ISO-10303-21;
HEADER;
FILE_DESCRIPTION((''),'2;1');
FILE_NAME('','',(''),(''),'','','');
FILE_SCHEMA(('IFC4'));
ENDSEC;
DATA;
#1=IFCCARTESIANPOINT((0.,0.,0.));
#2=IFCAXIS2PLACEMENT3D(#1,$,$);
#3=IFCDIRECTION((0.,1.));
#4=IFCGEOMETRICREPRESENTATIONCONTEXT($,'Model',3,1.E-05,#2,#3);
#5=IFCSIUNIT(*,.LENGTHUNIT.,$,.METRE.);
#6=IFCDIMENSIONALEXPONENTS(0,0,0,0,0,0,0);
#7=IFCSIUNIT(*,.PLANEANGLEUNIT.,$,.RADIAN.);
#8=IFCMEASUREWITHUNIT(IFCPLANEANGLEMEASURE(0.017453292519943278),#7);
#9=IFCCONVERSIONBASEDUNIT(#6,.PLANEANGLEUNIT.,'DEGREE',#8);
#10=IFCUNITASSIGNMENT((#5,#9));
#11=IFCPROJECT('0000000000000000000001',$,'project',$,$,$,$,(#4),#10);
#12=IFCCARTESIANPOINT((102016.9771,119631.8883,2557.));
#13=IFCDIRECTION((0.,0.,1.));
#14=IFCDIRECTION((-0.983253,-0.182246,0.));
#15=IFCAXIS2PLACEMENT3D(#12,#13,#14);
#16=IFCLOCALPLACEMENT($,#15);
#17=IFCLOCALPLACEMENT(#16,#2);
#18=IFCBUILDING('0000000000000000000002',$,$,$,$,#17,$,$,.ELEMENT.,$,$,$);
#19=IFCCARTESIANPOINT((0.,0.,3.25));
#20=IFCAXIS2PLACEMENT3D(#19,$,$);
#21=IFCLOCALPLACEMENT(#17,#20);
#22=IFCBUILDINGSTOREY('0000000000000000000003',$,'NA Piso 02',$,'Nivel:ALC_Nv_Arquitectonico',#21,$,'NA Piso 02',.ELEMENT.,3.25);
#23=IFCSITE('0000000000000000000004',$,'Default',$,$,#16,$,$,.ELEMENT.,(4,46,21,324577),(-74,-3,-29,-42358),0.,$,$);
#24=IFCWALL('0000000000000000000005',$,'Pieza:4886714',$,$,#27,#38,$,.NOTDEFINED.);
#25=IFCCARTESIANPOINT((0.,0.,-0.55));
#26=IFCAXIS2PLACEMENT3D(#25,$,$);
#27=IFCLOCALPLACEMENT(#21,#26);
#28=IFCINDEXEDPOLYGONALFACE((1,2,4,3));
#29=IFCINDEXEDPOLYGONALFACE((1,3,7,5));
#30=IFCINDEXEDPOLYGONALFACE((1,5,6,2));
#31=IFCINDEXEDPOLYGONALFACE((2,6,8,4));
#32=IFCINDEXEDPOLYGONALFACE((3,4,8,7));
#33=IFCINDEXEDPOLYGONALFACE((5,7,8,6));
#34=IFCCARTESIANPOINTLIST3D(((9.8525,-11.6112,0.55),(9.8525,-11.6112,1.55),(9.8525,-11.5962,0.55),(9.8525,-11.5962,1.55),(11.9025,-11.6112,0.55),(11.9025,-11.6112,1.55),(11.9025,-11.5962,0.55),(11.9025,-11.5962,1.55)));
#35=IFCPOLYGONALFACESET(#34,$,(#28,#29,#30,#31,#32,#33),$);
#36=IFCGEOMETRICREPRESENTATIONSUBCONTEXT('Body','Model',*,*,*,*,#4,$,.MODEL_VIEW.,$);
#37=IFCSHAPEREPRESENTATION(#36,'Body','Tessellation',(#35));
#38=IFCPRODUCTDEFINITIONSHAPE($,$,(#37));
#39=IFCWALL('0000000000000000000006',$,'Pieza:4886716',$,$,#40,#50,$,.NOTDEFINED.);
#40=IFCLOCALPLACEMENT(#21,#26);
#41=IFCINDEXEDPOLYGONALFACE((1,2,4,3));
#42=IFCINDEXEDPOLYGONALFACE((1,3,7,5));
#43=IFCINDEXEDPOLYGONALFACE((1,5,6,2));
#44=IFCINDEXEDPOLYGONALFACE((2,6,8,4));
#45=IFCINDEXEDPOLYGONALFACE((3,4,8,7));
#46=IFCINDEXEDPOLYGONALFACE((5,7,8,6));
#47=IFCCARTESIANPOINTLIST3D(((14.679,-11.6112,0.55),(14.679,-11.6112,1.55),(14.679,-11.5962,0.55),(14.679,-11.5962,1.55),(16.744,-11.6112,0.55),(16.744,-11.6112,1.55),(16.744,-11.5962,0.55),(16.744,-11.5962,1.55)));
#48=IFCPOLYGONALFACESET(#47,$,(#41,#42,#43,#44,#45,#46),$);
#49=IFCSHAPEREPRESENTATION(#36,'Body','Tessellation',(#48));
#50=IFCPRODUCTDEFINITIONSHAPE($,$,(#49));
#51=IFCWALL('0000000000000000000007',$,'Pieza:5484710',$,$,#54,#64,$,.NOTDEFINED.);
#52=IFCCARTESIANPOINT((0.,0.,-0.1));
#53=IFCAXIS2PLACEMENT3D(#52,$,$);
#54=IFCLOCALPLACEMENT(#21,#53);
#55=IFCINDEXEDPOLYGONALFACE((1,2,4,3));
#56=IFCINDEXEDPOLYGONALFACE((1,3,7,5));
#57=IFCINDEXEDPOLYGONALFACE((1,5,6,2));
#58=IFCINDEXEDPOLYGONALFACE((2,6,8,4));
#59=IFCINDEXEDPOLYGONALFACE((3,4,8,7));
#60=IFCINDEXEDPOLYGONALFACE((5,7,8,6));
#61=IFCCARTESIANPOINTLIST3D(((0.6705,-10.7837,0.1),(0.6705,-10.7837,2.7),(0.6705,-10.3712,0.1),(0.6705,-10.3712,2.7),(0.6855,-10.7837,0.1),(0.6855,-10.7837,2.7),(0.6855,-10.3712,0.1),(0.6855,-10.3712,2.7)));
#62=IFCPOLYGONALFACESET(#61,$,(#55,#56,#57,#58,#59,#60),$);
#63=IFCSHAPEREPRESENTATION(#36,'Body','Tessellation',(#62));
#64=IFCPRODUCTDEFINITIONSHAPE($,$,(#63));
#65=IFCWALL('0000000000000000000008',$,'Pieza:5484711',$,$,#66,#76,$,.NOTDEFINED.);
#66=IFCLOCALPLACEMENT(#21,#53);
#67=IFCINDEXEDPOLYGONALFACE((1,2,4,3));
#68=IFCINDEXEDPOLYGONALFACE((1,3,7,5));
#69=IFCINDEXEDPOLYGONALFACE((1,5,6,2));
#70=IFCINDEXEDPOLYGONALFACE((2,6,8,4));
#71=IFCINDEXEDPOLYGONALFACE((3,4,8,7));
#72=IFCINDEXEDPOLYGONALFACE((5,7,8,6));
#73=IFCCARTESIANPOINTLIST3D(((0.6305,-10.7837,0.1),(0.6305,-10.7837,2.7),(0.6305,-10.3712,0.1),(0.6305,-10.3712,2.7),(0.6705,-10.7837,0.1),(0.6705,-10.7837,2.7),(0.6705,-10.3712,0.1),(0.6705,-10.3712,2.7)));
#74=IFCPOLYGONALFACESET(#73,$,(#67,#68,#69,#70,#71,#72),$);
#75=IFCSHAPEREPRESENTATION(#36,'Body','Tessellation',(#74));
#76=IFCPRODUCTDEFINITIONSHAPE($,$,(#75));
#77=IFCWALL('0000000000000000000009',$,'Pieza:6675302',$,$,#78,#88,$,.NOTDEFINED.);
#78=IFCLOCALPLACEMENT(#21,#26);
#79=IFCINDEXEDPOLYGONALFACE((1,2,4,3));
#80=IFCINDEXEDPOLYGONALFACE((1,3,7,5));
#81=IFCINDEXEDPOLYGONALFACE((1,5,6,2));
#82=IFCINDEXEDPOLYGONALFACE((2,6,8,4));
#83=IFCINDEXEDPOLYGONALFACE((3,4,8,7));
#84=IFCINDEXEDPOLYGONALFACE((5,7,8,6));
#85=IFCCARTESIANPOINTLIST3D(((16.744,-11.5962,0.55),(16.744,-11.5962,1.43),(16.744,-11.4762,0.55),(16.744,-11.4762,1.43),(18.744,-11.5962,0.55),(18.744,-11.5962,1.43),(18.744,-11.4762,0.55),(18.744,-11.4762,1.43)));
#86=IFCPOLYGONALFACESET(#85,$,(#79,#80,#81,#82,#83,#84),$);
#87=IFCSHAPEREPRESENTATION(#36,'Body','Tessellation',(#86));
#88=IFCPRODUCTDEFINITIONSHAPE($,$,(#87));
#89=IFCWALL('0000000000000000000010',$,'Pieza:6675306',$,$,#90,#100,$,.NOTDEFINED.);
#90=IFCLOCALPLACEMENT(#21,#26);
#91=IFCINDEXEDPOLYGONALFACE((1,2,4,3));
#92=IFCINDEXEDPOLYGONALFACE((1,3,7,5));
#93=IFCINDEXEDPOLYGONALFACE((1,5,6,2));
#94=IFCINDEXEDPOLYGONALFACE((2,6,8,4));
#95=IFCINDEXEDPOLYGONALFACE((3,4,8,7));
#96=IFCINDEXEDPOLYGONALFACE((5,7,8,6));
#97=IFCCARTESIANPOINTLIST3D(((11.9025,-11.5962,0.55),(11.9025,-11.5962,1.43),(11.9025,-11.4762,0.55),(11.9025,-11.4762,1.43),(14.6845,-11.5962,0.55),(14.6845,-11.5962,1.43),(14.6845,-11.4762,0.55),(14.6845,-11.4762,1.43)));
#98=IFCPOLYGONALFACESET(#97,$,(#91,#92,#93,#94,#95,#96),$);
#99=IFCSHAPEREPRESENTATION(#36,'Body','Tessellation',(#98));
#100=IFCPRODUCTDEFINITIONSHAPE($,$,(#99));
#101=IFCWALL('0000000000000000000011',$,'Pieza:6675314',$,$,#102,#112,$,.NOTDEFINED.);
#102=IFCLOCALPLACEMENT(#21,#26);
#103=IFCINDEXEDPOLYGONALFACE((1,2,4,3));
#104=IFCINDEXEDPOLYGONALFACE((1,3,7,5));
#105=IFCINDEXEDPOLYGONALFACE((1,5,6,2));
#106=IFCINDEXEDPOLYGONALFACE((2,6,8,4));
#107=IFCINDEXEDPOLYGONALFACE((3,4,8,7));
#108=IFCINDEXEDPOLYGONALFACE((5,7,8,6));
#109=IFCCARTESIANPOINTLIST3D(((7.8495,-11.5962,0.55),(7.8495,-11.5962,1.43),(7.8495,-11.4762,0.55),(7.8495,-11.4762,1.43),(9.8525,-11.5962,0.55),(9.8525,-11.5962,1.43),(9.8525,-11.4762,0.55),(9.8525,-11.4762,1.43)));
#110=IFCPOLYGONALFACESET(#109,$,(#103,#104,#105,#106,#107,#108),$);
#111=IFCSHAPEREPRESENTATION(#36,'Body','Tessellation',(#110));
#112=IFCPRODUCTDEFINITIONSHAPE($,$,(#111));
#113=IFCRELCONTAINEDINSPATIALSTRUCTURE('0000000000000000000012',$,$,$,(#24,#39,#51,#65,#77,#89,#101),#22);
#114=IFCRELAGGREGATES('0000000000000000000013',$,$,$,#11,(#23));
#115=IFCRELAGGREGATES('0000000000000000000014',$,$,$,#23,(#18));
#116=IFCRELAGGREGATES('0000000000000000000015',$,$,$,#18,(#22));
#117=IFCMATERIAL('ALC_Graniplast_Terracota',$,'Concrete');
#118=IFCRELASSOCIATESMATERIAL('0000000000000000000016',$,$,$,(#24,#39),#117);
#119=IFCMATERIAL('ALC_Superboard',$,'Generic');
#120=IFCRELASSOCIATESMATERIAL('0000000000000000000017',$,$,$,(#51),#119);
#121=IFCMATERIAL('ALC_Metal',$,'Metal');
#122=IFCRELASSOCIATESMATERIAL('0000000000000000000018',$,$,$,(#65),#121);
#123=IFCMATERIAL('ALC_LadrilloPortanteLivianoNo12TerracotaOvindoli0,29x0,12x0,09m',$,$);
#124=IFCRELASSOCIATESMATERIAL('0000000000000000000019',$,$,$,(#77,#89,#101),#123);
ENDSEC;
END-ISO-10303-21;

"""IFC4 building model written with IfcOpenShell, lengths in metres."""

from ifc_helpers import new_model, entity, si_unit, converted_unit, direction, frame, frame_2d, origin, origin_2d_with_axis, place, context, subcontext, project, spatial, rectangle, extrude, material, element, save


model = new_model("IFC4")

# Units and contexts
model_context = context("Model", 3, precision=1e-05, world=origin(), true_north=direction((0.0, 1.0)))
body_context = subcontext(model_context, "Body", "Model", "MODEL_VIEW")
ifc_project = project(units=[si_unit("LENGTHUNIT", "METRE"), converted_unit("PLANEANGLEUNIT", "DEGREE", entity("IfcPlaneAngleMeasure", 0.017453292519943278), si_unit("PLANEANGLEUNIT", "RADIAN"), dimensions=[0, 0, 0, 0, 0, 0, 0])], contexts=[model_context])

# Site, building, storey
site_placement = place(None, frame((102016.9771, 119631.8883, 2557.0), z_axis=(0.0, 0.0, 1.0), x_axis=(-0.983253, -0.182246, 0.0)))
site = spatial("IfcSite", under=ifc_project, at=site_placement, Name="Default", CompositionType="ELEMENT", RefLatitude=(4, 46, 21, 324577), RefLongitude=(-74, -3, -29, -42358), RefElevation=0.0)
building_placement = place(site_placement, origin())
building = spatial("IfcBuilding", under=site, at=building_placement, CompositionType="ELEMENT")
storey_placement = place(building_placement, frame((0.0, 0.0, 3.25)))
storey = spatial("IfcBuildingStorey", under=building, at=storey_placement, Name="NA Piso 02", ObjectType="Nivel:ALC_Nv_Arquitectonico", LongName="NA Piso 02", CompositionType="ELEMENT", Elevation=3.25)

# Walls
ifc_material_1 = material(Name="ALC_Graniplast_Terracota", Category="Concrete")
wall_1_placement = place(storey_placement, frame((0.0, 0.0, -0.55)))
element("IfcWall", 1, at=wall_1_placement, inside=storey, material=ifc_material_1, Name="Pieza:4886714", PredefinedType="NOTDEFINED", context=body_context, shape_type="SweptSolid", body=[
    extrude(rectangle(XDim=0.015, YDim=2.05, at=frame_2d((0.0, 0.0), x_axis=(1.0, 0.0))), frame((10.8775, -11.6037, 0.55), z_axis=(0.0, 0.0, 1.0), x_axis=(0.0, -1.0, 0.0)), (0.0, 0.0, 1.0), 1.0),
])
wall_2_placement = place(storey_placement, frame((0.0, 0.0, -0.55)))
element("IfcWall", 2, at=wall_2_placement, inside=storey, material=ifc_material_1, Name="Pieza:4886716", PredefinedType="NOTDEFINED", context=body_context, shape_type="SweptSolid", body=[
    extrude(rectangle(XDim=0.015, YDim=2.065, at=frame_2d((0.0, 0.0), x_axis=(1.0, 0.0))), frame((15.7115, -11.6037, 0.55), z_axis=(0.0, 0.0, 1.0), x_axis=(0.0, -1.0, 0.0)), (0.0, 0.0, 1.0), 1.0),
])
ifc_material_2 = material(Name="ALC_Superboard", Category="Generic")
wall_3_placement = place(storey_placement, frame((0.0, 0.0, -0.1)))
element("IfcWall", 3, at=wall_3_placement, inside=storey, material=ifc_material_2, Name="Pieza:5484710", PredefinedType="NOTDEFINED", context=body_context, shape_type="SweptSolid", body=[
    extrude(rectangle(XDim=0.4125, YDim=0.015, at=frame_2d((0.0, 0.0), x_axis=(1.0, 0.0))), frame((0.678, -10.5774, 0.1), z_axis=(0.0, 0.0, 1.0), x_axis=(0.0, -1.0, 0.0)), (0.0, 0.0, 1.0), 2.6),
])
ifc_material_3 = material(Name="ALC_Metal", Category="Metal")
wall_4_placement = place(storey_placement, frame((0.0, 0.0, -0.1)))
element("IfcWall", 4, at=wall_4_placement, inside=storey, material=ifc_material_3, Name="Pieza:5484711", PredefinedType="NOTDEFINED", context=body_context, shape_type="SweptSolid", body=[
    extrude(rectangle(XDim=0.4125, YDim=0.04, at=frame_2d((0.0, 0.0), x_axis=(1.0, 0.0))), frame((0.6505, -10.5774, 0.1), z_axis=(0.0, 0.0, 1.0), x_axis=(0.0, -1.0, 0.0)), (0.0, 0.0, 1.0), 2.6),
])
ifc_material_4 = material(Name="ALC_LadrilloPortanteLivianoNo12TerracotaOvindoli0,29x0,12x0,09m")
wall_5_placement = place(storey_placement, frame((0.0, 0.0, -0.55)))
element("IfcWall", 5, at=wall_5_placement, inside=storey, material=ifc_material_4, Name="Pieza:6675302", PredefinedType="NOTDEFINED", context=body_context, shape_type="SweptSolid", body=[
    extrude(rectangle(XDim=0.12, YDim=2.0, at=frame_2d((0.0, 0.0), x_axis=(1.0, 0.0))), frame((17.744, -11.5362, 0.55), z_axis=(0.0, 0.0, 1.0), x_axis=(0.0, -1.0, 0.0)), (0.0, 0.0, 1.0), 0.88),
])
wall_6_placement = place(storey_placement, frame((0.0, 0.0, -0.55)))
element("IfcWall", 6, at=wall_6_placement, inside=storey, material=ifc_material_4, Name="Pieza:6675306", PredefinedType="NOTDEFINED", context=body_context, shape_type="SweptSolid", body=[
    extrude(rectangle(XDim=0.12, YDim=2.782, at=origin_2d_with_axis()), frame((13.2935, -11.5362, 0.55), z_axis=(0.0, 0.0, 1.0), x_axis=(0.0, -1.0, 0.0)), (0.0, 0.0, 1.0), 0.88),
])
wall_7_placement = place(storey_placement, frame((0.0, 0.0, -0.55)))
element("IfcWall", 7, at=wall_7_placement, inside=storey, material=ifc_material_4, Name="Pieza:6675314", PredefinedType="NOTDEFINED", context=body_context, shape_type="SweptSolid", body=[
    extrude(rectangle(XDim=0.12, YDim=2.003, at=origin_2d_with_axis()), frame((8.851, -11.5362, 0.55), z_axis=(0.0, 0.0, 1.0), x_axis=(0.0, -1.0, 0.0)), (0.0, 0.0, 1.0), 0.88),
])

save(model, "model.ifc")
